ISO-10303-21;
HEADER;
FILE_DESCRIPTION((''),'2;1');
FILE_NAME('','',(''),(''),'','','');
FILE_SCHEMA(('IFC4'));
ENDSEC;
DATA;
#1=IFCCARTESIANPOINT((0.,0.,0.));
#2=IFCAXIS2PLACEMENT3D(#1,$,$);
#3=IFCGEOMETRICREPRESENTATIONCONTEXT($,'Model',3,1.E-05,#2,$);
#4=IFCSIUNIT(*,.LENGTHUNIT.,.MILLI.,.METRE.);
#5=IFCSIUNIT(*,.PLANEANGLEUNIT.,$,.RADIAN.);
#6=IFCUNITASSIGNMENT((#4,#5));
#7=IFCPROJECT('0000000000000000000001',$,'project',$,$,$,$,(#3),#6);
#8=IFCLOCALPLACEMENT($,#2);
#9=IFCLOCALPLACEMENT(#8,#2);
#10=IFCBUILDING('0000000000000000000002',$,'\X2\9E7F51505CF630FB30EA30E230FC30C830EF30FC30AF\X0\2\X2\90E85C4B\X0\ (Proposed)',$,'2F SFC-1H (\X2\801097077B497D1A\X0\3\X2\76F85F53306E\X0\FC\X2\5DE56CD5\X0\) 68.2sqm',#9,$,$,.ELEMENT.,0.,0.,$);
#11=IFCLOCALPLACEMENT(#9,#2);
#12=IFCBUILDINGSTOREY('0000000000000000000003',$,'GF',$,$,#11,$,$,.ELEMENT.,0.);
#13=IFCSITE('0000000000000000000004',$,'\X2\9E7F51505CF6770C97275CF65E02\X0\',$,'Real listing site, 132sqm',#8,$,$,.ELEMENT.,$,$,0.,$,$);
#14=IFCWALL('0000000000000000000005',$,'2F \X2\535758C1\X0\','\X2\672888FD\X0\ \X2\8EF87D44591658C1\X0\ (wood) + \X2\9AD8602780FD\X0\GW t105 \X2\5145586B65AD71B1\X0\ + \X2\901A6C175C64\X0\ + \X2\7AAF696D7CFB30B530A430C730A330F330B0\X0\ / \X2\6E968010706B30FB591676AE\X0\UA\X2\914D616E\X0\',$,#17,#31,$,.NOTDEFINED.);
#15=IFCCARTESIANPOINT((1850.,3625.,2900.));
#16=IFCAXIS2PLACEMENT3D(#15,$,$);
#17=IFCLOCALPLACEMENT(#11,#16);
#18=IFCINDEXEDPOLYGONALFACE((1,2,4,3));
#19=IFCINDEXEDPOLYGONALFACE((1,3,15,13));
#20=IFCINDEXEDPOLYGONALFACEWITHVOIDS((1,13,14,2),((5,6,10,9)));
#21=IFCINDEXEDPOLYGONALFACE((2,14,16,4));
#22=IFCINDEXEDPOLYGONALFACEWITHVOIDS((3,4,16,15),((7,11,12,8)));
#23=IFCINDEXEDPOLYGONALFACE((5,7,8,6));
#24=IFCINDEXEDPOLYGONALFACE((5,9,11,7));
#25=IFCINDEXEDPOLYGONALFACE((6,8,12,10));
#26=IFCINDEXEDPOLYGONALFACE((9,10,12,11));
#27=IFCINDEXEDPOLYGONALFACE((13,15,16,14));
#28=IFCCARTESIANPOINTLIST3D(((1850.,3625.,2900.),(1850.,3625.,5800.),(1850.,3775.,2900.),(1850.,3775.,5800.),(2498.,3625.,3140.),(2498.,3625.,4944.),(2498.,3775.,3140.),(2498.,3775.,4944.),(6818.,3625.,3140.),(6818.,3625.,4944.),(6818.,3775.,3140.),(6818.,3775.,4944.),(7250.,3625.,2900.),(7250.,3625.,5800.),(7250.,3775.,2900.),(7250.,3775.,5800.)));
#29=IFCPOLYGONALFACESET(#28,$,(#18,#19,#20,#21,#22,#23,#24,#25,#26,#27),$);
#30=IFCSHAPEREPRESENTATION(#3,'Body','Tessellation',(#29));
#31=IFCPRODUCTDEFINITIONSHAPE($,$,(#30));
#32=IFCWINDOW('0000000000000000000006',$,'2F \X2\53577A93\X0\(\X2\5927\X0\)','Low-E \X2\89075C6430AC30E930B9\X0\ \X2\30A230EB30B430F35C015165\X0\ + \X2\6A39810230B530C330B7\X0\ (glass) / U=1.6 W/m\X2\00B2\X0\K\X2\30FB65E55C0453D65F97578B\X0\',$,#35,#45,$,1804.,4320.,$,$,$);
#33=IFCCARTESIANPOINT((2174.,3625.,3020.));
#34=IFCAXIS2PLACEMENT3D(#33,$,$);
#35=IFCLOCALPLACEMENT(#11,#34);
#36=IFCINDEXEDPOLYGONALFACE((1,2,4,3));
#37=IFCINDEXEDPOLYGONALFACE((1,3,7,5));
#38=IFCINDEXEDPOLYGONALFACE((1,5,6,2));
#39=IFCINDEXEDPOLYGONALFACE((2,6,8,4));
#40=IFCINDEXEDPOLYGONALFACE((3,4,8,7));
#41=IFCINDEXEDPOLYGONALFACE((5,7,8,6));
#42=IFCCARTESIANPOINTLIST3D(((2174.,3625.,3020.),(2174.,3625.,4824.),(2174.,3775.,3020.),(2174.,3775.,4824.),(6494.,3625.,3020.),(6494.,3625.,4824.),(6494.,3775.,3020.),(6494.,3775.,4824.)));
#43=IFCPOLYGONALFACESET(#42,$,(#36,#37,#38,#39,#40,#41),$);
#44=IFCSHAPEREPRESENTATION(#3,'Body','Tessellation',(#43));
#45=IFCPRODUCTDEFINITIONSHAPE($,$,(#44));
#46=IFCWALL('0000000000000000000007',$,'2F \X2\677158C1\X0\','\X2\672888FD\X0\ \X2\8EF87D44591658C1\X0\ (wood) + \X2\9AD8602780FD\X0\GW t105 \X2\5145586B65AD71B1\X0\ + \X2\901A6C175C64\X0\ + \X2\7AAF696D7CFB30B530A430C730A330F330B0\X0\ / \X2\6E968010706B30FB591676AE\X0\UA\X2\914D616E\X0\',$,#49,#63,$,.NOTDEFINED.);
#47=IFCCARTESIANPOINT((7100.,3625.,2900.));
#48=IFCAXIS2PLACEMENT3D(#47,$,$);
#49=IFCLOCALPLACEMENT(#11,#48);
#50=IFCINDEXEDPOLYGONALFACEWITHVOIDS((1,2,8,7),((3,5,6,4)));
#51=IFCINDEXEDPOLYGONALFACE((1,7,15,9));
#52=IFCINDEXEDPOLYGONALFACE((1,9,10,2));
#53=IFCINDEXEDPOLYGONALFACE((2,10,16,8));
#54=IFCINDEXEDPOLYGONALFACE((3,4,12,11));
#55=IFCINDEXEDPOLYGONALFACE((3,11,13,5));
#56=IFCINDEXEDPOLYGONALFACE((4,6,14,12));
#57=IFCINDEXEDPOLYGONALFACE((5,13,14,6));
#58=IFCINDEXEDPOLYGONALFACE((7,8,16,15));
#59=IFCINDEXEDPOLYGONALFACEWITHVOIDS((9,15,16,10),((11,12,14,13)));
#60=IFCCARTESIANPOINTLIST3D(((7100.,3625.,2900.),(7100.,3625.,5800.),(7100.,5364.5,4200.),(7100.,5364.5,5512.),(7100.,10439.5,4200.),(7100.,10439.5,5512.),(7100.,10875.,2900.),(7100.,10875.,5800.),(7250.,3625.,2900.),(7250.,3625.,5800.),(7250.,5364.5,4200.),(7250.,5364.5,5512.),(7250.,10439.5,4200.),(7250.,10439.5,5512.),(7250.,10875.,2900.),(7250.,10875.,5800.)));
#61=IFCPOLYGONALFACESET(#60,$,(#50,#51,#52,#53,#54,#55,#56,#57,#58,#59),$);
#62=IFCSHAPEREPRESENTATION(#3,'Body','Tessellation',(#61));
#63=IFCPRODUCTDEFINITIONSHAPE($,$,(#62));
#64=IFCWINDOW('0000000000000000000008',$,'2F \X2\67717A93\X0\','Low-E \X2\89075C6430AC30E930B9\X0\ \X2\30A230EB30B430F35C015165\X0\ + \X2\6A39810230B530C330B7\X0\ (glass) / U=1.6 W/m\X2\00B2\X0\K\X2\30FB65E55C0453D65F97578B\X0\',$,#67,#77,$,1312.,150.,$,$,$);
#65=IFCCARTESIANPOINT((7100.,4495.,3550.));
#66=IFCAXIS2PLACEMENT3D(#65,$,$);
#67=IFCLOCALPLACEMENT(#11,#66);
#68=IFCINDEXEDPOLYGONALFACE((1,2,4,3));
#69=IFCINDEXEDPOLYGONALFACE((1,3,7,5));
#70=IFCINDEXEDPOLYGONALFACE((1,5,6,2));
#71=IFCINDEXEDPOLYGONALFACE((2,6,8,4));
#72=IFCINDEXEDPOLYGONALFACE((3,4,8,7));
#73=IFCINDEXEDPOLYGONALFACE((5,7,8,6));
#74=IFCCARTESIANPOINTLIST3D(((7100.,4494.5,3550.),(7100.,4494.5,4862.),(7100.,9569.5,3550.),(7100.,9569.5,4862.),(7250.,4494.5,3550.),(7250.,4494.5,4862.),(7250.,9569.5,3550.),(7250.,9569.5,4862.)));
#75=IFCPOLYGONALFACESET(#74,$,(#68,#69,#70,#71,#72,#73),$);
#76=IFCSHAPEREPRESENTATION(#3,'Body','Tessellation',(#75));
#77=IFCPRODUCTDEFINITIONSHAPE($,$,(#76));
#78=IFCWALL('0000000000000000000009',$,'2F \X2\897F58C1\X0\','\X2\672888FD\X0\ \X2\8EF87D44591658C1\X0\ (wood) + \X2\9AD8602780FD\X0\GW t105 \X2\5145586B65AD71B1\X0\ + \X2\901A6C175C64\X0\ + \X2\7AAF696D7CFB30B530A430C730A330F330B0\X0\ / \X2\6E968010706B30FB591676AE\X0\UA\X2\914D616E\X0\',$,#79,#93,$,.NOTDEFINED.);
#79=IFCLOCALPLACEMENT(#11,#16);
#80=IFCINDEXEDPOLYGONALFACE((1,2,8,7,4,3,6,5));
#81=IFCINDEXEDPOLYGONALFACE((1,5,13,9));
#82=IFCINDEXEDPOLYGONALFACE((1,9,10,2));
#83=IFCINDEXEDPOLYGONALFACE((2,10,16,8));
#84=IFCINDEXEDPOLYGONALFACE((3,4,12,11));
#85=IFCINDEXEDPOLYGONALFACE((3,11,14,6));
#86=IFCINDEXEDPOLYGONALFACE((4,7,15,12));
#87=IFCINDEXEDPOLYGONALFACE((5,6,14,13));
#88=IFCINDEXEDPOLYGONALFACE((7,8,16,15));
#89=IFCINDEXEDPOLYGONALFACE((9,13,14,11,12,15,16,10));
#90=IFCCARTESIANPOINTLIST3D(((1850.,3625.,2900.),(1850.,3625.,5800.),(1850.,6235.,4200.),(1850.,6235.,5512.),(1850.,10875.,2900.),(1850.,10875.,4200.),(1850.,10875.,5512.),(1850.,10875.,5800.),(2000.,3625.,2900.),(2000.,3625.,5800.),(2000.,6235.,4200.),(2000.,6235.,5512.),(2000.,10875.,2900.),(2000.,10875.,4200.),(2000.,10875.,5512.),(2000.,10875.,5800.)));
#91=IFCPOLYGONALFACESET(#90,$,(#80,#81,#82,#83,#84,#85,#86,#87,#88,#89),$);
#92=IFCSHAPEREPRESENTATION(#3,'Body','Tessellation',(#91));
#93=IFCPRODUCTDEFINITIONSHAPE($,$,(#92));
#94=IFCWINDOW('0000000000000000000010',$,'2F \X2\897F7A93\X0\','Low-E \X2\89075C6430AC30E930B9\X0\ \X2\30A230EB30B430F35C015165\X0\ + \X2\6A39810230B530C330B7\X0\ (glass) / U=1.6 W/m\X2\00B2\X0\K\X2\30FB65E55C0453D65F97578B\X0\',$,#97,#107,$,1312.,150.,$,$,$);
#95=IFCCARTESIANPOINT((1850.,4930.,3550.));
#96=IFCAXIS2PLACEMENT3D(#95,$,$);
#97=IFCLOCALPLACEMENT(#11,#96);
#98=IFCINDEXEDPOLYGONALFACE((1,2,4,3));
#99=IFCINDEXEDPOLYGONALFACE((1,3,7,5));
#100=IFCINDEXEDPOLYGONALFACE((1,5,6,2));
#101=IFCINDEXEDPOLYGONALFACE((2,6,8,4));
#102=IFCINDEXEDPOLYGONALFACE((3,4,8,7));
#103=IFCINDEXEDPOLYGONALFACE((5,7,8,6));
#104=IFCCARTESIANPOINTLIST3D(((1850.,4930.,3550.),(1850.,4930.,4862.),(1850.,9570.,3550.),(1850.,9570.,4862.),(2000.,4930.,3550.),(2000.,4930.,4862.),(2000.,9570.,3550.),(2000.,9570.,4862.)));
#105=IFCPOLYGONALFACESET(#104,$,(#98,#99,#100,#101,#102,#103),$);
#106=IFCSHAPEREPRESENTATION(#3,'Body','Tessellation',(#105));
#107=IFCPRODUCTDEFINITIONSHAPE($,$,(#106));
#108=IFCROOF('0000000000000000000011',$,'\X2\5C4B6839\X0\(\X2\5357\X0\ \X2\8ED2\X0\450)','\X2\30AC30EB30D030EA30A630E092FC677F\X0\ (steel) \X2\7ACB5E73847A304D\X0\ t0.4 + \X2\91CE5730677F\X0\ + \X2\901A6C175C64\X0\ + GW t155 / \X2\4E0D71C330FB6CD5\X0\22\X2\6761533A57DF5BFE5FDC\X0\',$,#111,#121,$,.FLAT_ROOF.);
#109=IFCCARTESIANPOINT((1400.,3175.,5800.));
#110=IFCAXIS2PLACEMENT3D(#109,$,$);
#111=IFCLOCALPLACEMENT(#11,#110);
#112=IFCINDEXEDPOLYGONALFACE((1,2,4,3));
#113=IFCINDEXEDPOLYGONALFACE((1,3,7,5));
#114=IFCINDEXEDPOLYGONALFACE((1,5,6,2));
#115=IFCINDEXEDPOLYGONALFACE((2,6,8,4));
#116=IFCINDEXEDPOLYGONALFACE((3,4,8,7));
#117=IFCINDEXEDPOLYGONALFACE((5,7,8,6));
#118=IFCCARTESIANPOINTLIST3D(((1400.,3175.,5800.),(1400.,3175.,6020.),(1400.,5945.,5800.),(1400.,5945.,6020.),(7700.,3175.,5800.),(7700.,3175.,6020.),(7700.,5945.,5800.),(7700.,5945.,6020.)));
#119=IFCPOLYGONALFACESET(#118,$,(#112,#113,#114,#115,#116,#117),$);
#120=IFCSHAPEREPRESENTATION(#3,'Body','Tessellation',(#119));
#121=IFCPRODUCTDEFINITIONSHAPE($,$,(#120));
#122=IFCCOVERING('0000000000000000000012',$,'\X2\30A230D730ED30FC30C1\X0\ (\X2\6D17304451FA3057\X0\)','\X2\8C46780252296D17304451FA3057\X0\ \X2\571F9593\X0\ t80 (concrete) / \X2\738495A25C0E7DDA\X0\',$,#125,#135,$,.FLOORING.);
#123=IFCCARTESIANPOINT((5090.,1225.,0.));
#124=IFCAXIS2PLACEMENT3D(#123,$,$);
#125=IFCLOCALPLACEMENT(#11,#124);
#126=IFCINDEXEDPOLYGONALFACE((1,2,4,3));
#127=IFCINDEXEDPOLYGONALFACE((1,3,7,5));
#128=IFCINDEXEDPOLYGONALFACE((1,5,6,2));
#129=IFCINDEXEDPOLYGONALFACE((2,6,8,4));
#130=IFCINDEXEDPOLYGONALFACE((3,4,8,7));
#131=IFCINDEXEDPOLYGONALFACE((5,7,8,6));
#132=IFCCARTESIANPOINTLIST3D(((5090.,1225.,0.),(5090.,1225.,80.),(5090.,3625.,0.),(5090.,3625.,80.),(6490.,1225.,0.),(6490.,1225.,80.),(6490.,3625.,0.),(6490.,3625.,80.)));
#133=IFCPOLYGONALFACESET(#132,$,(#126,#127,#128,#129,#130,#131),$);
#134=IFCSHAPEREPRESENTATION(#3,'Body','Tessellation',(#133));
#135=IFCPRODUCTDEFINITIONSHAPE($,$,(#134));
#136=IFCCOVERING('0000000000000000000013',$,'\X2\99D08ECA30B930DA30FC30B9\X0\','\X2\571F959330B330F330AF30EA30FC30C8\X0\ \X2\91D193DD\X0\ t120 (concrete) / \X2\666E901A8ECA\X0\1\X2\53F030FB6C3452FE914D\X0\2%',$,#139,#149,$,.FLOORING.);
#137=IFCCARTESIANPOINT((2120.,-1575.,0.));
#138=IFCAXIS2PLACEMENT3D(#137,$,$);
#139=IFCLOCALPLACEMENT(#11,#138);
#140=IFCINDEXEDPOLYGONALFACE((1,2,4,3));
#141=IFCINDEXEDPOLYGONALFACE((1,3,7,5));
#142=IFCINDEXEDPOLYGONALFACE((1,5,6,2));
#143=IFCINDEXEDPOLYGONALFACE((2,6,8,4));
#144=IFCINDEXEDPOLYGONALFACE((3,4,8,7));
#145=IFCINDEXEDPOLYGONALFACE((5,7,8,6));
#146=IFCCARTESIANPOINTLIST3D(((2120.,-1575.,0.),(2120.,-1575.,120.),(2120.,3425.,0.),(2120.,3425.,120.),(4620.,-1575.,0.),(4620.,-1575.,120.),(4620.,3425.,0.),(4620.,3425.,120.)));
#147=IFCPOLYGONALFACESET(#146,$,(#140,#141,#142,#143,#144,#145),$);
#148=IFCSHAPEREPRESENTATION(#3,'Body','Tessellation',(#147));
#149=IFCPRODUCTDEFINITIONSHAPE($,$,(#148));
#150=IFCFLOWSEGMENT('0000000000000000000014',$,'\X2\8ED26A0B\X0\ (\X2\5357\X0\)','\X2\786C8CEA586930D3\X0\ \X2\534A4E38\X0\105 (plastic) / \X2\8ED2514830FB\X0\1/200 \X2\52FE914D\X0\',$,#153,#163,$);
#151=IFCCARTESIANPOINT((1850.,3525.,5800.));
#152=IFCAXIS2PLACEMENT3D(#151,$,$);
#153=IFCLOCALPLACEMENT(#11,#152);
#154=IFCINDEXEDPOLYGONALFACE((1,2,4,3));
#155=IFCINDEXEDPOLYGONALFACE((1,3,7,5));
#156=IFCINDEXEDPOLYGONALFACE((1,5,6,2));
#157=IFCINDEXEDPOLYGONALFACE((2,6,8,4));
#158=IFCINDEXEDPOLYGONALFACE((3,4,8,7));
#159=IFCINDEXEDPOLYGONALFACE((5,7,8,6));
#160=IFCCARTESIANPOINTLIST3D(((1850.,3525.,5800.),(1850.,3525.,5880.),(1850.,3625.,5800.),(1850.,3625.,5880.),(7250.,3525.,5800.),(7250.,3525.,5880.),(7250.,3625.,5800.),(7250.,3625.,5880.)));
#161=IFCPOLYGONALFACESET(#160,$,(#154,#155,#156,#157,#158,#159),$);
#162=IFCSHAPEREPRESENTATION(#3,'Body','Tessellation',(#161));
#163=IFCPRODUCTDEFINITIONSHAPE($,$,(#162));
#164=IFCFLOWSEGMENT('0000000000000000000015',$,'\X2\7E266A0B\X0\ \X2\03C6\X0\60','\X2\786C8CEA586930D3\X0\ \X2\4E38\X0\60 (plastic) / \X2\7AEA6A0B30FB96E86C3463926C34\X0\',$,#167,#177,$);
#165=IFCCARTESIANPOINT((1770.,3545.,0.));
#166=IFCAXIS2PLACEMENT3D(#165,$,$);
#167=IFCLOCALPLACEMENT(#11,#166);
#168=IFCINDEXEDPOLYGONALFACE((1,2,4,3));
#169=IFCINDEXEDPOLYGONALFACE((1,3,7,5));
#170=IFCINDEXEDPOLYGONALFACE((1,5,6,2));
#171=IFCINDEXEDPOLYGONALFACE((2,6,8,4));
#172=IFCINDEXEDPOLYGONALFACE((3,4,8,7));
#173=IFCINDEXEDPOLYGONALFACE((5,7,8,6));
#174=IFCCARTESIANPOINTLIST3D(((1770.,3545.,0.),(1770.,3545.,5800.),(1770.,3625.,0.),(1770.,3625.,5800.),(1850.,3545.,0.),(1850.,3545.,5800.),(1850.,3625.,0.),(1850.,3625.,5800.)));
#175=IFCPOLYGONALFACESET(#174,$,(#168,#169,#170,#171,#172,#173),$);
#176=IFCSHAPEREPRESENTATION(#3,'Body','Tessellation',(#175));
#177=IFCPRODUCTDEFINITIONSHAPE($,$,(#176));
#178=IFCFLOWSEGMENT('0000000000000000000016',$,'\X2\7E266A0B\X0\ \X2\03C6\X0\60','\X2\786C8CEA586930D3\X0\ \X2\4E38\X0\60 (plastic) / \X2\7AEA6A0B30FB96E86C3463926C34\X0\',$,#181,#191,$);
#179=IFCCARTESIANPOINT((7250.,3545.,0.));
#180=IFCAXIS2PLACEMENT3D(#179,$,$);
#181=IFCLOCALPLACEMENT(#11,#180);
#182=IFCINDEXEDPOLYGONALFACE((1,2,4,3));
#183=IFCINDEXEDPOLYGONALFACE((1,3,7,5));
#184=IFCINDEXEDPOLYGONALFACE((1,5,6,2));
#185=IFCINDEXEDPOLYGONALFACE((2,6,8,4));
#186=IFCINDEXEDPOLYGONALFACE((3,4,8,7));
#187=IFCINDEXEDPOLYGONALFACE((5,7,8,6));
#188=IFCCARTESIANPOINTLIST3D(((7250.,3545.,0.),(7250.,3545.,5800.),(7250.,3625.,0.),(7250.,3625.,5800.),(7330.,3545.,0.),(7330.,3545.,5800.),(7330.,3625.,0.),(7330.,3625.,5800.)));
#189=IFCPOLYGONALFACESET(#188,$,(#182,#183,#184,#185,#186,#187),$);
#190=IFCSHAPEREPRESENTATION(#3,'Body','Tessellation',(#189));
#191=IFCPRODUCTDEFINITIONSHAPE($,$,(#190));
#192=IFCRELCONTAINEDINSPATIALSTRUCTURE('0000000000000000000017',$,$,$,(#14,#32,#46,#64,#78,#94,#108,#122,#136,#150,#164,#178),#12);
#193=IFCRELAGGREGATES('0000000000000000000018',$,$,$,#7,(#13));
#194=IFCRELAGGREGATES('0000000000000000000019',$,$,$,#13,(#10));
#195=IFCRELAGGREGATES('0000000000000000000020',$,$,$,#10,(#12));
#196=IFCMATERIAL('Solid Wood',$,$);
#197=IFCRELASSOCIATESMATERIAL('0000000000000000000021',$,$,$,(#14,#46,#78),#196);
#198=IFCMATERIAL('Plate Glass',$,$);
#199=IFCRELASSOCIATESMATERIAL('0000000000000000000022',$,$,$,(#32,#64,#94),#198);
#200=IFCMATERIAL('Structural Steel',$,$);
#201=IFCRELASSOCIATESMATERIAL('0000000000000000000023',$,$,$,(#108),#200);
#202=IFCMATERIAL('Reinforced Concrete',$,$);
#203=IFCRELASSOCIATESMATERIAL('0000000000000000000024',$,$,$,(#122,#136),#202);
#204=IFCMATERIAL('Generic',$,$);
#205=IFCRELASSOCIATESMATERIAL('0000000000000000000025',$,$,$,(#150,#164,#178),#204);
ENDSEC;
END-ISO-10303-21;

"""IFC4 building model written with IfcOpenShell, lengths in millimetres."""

from ifc_helpers import new_model, si_unit, frame, frame_2d, origin, place, context, project, spatial, rectangle, extrude, material, element, fill, save


model = new_model("IFC4")

# Units and contexts
model_context = context("Model", 3, precision=1e-05, world=origin())
ifc_project = project(units=[si_unit("LENGTHUNIT", "METRE", prefix="MILLI"), si_unit("PLANEANGLEUNIT", "RADIAN")], contexts=[model_context])

# Site, building, storey
site_placement = place(None, origin())
site = spatial("IfcSite", under=ifc_project, at=site_placement, Name="鹿児島県霧島市", ObjectType="Real listing site, 132sqm", CompositionType="ELEMENT", RefElevation=0.0)
building_placement = place(site_placement, origin())
building = spatial("IfcBuilding", under=site, at=building_placement, Name="鹿児島・リモートワーク2部屋 (Proposed)", ObjectType="2F SFC-1H (耐震等級3相当のFC工法) 68.2sqm", CompositionType="ELEMENT", ElevationOfRefHeight=0.0, ElevationOfTerrain=0.0)
storey_placement = place(building_placement, origin())
storey = spatial("IfcBuildingStorey", under=building, at=storey_placement, Name="GF", CompositionType="ELEMENT", Elevation=0.0)

# Shared definitions
ifc_material_1 = material(Name="Solid Wood")

# Shared definitions
ifc_material_2 = material(Name="Reinforced Concrete")

# Shared definitions
ifc_material_3 = material(Name="Plate Glass")

# Walls, openings, windows
wall_1_placement = place(storey_placement, frame((1850.0, 3625.0, 2900.0)))
wall_1 = element("IfcWall", 1, at=wall_1_placement, inside=storey, material=ifc_material_1, Name="2F 南壁", Description="木製 軸組外壁 (wood) + 高性能GW t105 充填断熱 + 通気層 + 窯業系サイディング / 準耐火・外皮UA配慮", PredefinedType="NOTDEFINED", context=model_context, shape_type="SweptSolid", body=[
    extrude(rectangle(XDim=5400.0, YDim=150.0, at=frame_2d((2700.0, 75.0))), frame((1850.0, 3625.0, 2900.0)), (0.0, 0.0, 1.0), 2900.0),
])
opening_1_placement = place(storey_placement, frame((2174.0, 3625.0, 3020.0)))
opening_1 = element("IfcOpeningElement", 2, at=opening_1_placement, cuts=wall_1, PredefinedType="NOTDEFINED", context=model_context, shape_type="SweptSolid", body=[
    extrude(rectangle(XDim=4320.0, YDim=150.0, at=frame_2d((2160.0, 75.0))), frame((2174.0, 3625.0, 3020.0)), (0.0, 0.0, 1.0), 1804.0),
])
window_1_placement = place(storey_placement, frame((2174.0, 3625.0, 3020.0)))
window_1 = element("IfcWindow", 3, at=window_1_placement, inside=storey, material=ifc_material_3, Name="2F 南窓(大)", Description="Low-E 複層ガラス アルゴン封入 + 樹脂サッシ (glass) / U=1.6 W/m²K・日射取得型", OverallHeight=1804.0, OverallWidth=4320.0, context=model_context, shape_type="SweptSolid", body=[
    extrude(rectangle(XDim=4320.0, YDim=150.0, at=frame_2d((2160.0, 75.0))), frame((2174.0, 3625.0, 3020.0)), (0.0, 0.0, 1.0), 1804.0),
])
fill(opening_1, window_1)
wall_2_placement = place(storey_placement, frame((7100.0, 3625.0, 2900.0)))
wall_2 = element("IfcWall", 4, at=wall_2_placement, inside=storey, material=ifc_material_1, Name="2F 東壁", Description="木製 軸組外壁 (wood) + 高性能GW t105 充填断熱 + 通気層 + 窯業系サイディング / 準耐火・外皮UA配慮", PredefinedType="NOTDEFINED", context=model_context, shape_type="SweptSolid", body=[
    extrude(rectangle(XDim=150.0, YDim=7250.0, at=frame_2d((75.0, 3625.0))), frame((7100.0, 3625.0, 2900.0)), (0.0, 0.0, 1.0), 2900.0),
])
opening_2_placement = place(storey_placement, frame((7100.0, 4495.0, 3550.0)))
opening_2 = element("IfcOpeningElement", 5, at=opening_2_placement, cuts=wall_2, PredefinedType="NOTDEFINED", context=model_context, shape_type="SweptSolid", body=[
    extrude(rectangle(XDim=150.0, YDim=5075.0, at=frame_2d((75.0, 2537.0))), frame((7100.0, 4495.0, 3550.0)), (0.0, 0.0, 1.0), 1312.0),
])
window_2_placement = place(storey_placement, frame((7100.0, 4495.0, 3550.0)))
window_2 = element("IfcWindow", 6, at=window_2_placement, inside=storey, material=ifc_material_3, Name="2F 東窓", Description="Low-E 複層ガラス アルゴン封入 + 樹脂サッシ (glass) / U=1.6 W/m²K・日射取得型", OverallHeight=1312.0, OverallWidth=150.0, context=model_context, shape_type="SweptSolid", body=[
    extrude(rectangle(XDim=150.0, YDim=5075.0, at=frame_2d((75.0, 2537.0))), frame((7100.0, 4495.0, 3550.0)), (0.0, 0.0, 1.0), 1312.0),
])
fill(opening_2, window_2)
wall_3_placement = place(storey_placement, frame((1850.0, 3625.0, 2900.0)))
wall_3 = element("IfcWall", 7, at=wall_3_placement, inside=storey, material=ifc_material_1, Name="2F 西壁", Description="木製 軸組外壁 (wood) + 高性能GW t105 充填断熱 + 通気層 + 窯業系サイディング / 準耐火・外皮UA配慮", PredefinedType="NOTDEFINED", context=model_context, shape_type="SweptSolid", body=[
    extrude(rectangle(XDim=150.0, YDim=7250.0, at=frame_2d((75.0, 3625.0))), frame((1850.0, 3625.0, 2900.0)), (0.0, 0.0, 1.0), 2900.0),
])
opening_3_placement = place(storey_placement, frame((1850.0, 4930.0, 3550.0)))
opening_3 = element("IfcOpeningElement", 8, at=opening_3_placement, cuts=wall_3, PredefinedType="NOTDEFINED", context=model_context, shape_type="SweptSolid", body=[
    extrude(rectangle(XDim=150.0, YDim=4640.0, at=frame_2d((75.0, 2320.0))), frame((1850.0, 4930.0, 3550.0)), (0.0, 0.0, 1.0), 1312.0),
])
window_3_placement = place(storey_placement, frame((1850.0, 4930.0, 3550.0)))
window_3 = element("IfcWindow", 9, at=window_3_placement, inside=storey, material=ifc_material_3, Name="2F 西窓", Description="Low-E 複層ガラス アルゴン封入 + 樹脂サッシ (glass) / U=1.6 W/m²K・日射取得型", OverallHeight=1312.0, OverallWidth=150.0, context=model_context, shape_type="SweptSolid", body=[
    extrude(rectangle(XDim=150.0, YDim=4640.0, at=frame_2d((75.0, 2320.0))), frame((1850.0, 4930.0, 3550.0)), (0.0, 0.0, 1.0), 1312.0),
])
fill(opening_3, window_3)

# Roof
ifc_material_4 = material(Name="Structural Steel")
for number, where, name in (
    (10, (1400.0, 3175.0, 5800.0), "屋根(南 軒450)"),
):
    element("IfcRoof", number, at=place(storey_placement, frame(where)), inside=storey, material=ifc_material_4, Name=name, Description="ガルバリウム鋼板 (steel) 立平葺き t0.4 + 野地板 + 通気層 + GW t155 / 不燃・法22条区域対応", PredefinedType="FLAT_ROOF", context=model_context, shape_type="SweptSolid", body=[
        extrude(rectangle(XDim=6300.0, YDim=2770.0, at=frame_2d((3150.0, 1385.0))), frame((1400.0, 3175.0, 5800.0)), (0.0, 0.0, 1.0), 220.0),
    ])

# Coverings
covering_1_placement = place(storey_placement, frame((5090.0, 1225.0, 0.0)))
element("IfcCovering", 11, at=covering_1_placement, inside=storey, material=ifc_material_2, Name="アプローチ (洗い出し)", Description="豆砂利洗い出し 土間 t80 (concrete) / 玄関導線", PredefinedType="FLOORING", context=model_context, shape_type="SweptSolid", body=[
    extrude(rectangle(XDim=1400.0, YDim=2400.0, at=frame_2d((700.0, 1200.0))), frame((5090.0, 1225.0, 0.0)), (0.0, 0.0, 1.0), 80.0),
])
covering_2_placement = place(storey_placement, frame((2120.0, -1575.0, 0.0)))
element("IfcCovering", 12, at=covering_2_placement, inside=storey, material=ifc_material_2, Name="駐車スペース", Description="土間コンクリート 金鏝 t120 (concrete) / 普通車1台・水勾配2%", PredefinedType="FLOORING", context=model_context, shape_type="SweptSolid", body=[
    extrude(rectangle(XDim=2500.0, YDim=5000.0, at=frame_2d((1250.0, 2500.0))), frame((2120.0, -1575.0, 0.0)), (0.0, 0.0, 1.0), 120.0),
])

# Flow segments
ifc_material_5 = material(Name="Generic")
flow_segment_1_placement = place(storey_placement, frame((1850.0, 3525.0, 5800.0)))
element("IfcFlowSegment", 13, at=flow_segment_1_placement, inside=storey, material=ifc_material_5, Name="軒樋 (南)", Description="硬質塩ビ 半丸105 (plastic) / 軒先・1/200 勾配", context=model_context, shape_type="SweptSolid", body=[
    extrude(rectangle(XDim=5400.0, YDim=100.0, at=frame_2d((2700.0, 50.0))), frame((1850.0, 3525.0, 5800.0)), (0.0, 0.0, 1.0), 80.0),
])
flow_segment_2_placement = place(storey_placement, frame((1770.0, 3545.0, 0.0)))
element("IfcFlowSegment", 14, at=flow_segment_2_placement, inside=storey, material=ifc_material_5, Name="縦樋 φ60", Description="硬質塩ビ 丸60 (plastic) / 竪樋・雨水排水", context=model_context, shape_type="SweptSolid", body=[
    extrude(rectangle(XDim=80.0, YDim=80.0, at=frame_2d((40.0, 40.0))), frame((1770.0, 3545.0, 0.0)), (0.0, 0.0, 1.0), 5800.0),
])
flow_segment_3_placement = place(storey_placement, frame((7250.0, 3545.0, 0.0)))
element("IfcFlowSegment", 15, at=flow_segment_3_placement, inside=storey, material=ifc_material_5, Name="縦樋 φ60", Description="硬質塩ビ 丸60 (plastic) / 竪樋・雨水排水", context=model_context, shape_type="SweptSolid", body=[
    extrude(rectangle(XDim=80.0, YDim=80.0, at=frame_2d((40.0, 40.0))), frame((7250.0, 3545.0, 0.0)), (0.0, 0.0, 1.0), 5800.0),
])

save(model, "model.ifc")
